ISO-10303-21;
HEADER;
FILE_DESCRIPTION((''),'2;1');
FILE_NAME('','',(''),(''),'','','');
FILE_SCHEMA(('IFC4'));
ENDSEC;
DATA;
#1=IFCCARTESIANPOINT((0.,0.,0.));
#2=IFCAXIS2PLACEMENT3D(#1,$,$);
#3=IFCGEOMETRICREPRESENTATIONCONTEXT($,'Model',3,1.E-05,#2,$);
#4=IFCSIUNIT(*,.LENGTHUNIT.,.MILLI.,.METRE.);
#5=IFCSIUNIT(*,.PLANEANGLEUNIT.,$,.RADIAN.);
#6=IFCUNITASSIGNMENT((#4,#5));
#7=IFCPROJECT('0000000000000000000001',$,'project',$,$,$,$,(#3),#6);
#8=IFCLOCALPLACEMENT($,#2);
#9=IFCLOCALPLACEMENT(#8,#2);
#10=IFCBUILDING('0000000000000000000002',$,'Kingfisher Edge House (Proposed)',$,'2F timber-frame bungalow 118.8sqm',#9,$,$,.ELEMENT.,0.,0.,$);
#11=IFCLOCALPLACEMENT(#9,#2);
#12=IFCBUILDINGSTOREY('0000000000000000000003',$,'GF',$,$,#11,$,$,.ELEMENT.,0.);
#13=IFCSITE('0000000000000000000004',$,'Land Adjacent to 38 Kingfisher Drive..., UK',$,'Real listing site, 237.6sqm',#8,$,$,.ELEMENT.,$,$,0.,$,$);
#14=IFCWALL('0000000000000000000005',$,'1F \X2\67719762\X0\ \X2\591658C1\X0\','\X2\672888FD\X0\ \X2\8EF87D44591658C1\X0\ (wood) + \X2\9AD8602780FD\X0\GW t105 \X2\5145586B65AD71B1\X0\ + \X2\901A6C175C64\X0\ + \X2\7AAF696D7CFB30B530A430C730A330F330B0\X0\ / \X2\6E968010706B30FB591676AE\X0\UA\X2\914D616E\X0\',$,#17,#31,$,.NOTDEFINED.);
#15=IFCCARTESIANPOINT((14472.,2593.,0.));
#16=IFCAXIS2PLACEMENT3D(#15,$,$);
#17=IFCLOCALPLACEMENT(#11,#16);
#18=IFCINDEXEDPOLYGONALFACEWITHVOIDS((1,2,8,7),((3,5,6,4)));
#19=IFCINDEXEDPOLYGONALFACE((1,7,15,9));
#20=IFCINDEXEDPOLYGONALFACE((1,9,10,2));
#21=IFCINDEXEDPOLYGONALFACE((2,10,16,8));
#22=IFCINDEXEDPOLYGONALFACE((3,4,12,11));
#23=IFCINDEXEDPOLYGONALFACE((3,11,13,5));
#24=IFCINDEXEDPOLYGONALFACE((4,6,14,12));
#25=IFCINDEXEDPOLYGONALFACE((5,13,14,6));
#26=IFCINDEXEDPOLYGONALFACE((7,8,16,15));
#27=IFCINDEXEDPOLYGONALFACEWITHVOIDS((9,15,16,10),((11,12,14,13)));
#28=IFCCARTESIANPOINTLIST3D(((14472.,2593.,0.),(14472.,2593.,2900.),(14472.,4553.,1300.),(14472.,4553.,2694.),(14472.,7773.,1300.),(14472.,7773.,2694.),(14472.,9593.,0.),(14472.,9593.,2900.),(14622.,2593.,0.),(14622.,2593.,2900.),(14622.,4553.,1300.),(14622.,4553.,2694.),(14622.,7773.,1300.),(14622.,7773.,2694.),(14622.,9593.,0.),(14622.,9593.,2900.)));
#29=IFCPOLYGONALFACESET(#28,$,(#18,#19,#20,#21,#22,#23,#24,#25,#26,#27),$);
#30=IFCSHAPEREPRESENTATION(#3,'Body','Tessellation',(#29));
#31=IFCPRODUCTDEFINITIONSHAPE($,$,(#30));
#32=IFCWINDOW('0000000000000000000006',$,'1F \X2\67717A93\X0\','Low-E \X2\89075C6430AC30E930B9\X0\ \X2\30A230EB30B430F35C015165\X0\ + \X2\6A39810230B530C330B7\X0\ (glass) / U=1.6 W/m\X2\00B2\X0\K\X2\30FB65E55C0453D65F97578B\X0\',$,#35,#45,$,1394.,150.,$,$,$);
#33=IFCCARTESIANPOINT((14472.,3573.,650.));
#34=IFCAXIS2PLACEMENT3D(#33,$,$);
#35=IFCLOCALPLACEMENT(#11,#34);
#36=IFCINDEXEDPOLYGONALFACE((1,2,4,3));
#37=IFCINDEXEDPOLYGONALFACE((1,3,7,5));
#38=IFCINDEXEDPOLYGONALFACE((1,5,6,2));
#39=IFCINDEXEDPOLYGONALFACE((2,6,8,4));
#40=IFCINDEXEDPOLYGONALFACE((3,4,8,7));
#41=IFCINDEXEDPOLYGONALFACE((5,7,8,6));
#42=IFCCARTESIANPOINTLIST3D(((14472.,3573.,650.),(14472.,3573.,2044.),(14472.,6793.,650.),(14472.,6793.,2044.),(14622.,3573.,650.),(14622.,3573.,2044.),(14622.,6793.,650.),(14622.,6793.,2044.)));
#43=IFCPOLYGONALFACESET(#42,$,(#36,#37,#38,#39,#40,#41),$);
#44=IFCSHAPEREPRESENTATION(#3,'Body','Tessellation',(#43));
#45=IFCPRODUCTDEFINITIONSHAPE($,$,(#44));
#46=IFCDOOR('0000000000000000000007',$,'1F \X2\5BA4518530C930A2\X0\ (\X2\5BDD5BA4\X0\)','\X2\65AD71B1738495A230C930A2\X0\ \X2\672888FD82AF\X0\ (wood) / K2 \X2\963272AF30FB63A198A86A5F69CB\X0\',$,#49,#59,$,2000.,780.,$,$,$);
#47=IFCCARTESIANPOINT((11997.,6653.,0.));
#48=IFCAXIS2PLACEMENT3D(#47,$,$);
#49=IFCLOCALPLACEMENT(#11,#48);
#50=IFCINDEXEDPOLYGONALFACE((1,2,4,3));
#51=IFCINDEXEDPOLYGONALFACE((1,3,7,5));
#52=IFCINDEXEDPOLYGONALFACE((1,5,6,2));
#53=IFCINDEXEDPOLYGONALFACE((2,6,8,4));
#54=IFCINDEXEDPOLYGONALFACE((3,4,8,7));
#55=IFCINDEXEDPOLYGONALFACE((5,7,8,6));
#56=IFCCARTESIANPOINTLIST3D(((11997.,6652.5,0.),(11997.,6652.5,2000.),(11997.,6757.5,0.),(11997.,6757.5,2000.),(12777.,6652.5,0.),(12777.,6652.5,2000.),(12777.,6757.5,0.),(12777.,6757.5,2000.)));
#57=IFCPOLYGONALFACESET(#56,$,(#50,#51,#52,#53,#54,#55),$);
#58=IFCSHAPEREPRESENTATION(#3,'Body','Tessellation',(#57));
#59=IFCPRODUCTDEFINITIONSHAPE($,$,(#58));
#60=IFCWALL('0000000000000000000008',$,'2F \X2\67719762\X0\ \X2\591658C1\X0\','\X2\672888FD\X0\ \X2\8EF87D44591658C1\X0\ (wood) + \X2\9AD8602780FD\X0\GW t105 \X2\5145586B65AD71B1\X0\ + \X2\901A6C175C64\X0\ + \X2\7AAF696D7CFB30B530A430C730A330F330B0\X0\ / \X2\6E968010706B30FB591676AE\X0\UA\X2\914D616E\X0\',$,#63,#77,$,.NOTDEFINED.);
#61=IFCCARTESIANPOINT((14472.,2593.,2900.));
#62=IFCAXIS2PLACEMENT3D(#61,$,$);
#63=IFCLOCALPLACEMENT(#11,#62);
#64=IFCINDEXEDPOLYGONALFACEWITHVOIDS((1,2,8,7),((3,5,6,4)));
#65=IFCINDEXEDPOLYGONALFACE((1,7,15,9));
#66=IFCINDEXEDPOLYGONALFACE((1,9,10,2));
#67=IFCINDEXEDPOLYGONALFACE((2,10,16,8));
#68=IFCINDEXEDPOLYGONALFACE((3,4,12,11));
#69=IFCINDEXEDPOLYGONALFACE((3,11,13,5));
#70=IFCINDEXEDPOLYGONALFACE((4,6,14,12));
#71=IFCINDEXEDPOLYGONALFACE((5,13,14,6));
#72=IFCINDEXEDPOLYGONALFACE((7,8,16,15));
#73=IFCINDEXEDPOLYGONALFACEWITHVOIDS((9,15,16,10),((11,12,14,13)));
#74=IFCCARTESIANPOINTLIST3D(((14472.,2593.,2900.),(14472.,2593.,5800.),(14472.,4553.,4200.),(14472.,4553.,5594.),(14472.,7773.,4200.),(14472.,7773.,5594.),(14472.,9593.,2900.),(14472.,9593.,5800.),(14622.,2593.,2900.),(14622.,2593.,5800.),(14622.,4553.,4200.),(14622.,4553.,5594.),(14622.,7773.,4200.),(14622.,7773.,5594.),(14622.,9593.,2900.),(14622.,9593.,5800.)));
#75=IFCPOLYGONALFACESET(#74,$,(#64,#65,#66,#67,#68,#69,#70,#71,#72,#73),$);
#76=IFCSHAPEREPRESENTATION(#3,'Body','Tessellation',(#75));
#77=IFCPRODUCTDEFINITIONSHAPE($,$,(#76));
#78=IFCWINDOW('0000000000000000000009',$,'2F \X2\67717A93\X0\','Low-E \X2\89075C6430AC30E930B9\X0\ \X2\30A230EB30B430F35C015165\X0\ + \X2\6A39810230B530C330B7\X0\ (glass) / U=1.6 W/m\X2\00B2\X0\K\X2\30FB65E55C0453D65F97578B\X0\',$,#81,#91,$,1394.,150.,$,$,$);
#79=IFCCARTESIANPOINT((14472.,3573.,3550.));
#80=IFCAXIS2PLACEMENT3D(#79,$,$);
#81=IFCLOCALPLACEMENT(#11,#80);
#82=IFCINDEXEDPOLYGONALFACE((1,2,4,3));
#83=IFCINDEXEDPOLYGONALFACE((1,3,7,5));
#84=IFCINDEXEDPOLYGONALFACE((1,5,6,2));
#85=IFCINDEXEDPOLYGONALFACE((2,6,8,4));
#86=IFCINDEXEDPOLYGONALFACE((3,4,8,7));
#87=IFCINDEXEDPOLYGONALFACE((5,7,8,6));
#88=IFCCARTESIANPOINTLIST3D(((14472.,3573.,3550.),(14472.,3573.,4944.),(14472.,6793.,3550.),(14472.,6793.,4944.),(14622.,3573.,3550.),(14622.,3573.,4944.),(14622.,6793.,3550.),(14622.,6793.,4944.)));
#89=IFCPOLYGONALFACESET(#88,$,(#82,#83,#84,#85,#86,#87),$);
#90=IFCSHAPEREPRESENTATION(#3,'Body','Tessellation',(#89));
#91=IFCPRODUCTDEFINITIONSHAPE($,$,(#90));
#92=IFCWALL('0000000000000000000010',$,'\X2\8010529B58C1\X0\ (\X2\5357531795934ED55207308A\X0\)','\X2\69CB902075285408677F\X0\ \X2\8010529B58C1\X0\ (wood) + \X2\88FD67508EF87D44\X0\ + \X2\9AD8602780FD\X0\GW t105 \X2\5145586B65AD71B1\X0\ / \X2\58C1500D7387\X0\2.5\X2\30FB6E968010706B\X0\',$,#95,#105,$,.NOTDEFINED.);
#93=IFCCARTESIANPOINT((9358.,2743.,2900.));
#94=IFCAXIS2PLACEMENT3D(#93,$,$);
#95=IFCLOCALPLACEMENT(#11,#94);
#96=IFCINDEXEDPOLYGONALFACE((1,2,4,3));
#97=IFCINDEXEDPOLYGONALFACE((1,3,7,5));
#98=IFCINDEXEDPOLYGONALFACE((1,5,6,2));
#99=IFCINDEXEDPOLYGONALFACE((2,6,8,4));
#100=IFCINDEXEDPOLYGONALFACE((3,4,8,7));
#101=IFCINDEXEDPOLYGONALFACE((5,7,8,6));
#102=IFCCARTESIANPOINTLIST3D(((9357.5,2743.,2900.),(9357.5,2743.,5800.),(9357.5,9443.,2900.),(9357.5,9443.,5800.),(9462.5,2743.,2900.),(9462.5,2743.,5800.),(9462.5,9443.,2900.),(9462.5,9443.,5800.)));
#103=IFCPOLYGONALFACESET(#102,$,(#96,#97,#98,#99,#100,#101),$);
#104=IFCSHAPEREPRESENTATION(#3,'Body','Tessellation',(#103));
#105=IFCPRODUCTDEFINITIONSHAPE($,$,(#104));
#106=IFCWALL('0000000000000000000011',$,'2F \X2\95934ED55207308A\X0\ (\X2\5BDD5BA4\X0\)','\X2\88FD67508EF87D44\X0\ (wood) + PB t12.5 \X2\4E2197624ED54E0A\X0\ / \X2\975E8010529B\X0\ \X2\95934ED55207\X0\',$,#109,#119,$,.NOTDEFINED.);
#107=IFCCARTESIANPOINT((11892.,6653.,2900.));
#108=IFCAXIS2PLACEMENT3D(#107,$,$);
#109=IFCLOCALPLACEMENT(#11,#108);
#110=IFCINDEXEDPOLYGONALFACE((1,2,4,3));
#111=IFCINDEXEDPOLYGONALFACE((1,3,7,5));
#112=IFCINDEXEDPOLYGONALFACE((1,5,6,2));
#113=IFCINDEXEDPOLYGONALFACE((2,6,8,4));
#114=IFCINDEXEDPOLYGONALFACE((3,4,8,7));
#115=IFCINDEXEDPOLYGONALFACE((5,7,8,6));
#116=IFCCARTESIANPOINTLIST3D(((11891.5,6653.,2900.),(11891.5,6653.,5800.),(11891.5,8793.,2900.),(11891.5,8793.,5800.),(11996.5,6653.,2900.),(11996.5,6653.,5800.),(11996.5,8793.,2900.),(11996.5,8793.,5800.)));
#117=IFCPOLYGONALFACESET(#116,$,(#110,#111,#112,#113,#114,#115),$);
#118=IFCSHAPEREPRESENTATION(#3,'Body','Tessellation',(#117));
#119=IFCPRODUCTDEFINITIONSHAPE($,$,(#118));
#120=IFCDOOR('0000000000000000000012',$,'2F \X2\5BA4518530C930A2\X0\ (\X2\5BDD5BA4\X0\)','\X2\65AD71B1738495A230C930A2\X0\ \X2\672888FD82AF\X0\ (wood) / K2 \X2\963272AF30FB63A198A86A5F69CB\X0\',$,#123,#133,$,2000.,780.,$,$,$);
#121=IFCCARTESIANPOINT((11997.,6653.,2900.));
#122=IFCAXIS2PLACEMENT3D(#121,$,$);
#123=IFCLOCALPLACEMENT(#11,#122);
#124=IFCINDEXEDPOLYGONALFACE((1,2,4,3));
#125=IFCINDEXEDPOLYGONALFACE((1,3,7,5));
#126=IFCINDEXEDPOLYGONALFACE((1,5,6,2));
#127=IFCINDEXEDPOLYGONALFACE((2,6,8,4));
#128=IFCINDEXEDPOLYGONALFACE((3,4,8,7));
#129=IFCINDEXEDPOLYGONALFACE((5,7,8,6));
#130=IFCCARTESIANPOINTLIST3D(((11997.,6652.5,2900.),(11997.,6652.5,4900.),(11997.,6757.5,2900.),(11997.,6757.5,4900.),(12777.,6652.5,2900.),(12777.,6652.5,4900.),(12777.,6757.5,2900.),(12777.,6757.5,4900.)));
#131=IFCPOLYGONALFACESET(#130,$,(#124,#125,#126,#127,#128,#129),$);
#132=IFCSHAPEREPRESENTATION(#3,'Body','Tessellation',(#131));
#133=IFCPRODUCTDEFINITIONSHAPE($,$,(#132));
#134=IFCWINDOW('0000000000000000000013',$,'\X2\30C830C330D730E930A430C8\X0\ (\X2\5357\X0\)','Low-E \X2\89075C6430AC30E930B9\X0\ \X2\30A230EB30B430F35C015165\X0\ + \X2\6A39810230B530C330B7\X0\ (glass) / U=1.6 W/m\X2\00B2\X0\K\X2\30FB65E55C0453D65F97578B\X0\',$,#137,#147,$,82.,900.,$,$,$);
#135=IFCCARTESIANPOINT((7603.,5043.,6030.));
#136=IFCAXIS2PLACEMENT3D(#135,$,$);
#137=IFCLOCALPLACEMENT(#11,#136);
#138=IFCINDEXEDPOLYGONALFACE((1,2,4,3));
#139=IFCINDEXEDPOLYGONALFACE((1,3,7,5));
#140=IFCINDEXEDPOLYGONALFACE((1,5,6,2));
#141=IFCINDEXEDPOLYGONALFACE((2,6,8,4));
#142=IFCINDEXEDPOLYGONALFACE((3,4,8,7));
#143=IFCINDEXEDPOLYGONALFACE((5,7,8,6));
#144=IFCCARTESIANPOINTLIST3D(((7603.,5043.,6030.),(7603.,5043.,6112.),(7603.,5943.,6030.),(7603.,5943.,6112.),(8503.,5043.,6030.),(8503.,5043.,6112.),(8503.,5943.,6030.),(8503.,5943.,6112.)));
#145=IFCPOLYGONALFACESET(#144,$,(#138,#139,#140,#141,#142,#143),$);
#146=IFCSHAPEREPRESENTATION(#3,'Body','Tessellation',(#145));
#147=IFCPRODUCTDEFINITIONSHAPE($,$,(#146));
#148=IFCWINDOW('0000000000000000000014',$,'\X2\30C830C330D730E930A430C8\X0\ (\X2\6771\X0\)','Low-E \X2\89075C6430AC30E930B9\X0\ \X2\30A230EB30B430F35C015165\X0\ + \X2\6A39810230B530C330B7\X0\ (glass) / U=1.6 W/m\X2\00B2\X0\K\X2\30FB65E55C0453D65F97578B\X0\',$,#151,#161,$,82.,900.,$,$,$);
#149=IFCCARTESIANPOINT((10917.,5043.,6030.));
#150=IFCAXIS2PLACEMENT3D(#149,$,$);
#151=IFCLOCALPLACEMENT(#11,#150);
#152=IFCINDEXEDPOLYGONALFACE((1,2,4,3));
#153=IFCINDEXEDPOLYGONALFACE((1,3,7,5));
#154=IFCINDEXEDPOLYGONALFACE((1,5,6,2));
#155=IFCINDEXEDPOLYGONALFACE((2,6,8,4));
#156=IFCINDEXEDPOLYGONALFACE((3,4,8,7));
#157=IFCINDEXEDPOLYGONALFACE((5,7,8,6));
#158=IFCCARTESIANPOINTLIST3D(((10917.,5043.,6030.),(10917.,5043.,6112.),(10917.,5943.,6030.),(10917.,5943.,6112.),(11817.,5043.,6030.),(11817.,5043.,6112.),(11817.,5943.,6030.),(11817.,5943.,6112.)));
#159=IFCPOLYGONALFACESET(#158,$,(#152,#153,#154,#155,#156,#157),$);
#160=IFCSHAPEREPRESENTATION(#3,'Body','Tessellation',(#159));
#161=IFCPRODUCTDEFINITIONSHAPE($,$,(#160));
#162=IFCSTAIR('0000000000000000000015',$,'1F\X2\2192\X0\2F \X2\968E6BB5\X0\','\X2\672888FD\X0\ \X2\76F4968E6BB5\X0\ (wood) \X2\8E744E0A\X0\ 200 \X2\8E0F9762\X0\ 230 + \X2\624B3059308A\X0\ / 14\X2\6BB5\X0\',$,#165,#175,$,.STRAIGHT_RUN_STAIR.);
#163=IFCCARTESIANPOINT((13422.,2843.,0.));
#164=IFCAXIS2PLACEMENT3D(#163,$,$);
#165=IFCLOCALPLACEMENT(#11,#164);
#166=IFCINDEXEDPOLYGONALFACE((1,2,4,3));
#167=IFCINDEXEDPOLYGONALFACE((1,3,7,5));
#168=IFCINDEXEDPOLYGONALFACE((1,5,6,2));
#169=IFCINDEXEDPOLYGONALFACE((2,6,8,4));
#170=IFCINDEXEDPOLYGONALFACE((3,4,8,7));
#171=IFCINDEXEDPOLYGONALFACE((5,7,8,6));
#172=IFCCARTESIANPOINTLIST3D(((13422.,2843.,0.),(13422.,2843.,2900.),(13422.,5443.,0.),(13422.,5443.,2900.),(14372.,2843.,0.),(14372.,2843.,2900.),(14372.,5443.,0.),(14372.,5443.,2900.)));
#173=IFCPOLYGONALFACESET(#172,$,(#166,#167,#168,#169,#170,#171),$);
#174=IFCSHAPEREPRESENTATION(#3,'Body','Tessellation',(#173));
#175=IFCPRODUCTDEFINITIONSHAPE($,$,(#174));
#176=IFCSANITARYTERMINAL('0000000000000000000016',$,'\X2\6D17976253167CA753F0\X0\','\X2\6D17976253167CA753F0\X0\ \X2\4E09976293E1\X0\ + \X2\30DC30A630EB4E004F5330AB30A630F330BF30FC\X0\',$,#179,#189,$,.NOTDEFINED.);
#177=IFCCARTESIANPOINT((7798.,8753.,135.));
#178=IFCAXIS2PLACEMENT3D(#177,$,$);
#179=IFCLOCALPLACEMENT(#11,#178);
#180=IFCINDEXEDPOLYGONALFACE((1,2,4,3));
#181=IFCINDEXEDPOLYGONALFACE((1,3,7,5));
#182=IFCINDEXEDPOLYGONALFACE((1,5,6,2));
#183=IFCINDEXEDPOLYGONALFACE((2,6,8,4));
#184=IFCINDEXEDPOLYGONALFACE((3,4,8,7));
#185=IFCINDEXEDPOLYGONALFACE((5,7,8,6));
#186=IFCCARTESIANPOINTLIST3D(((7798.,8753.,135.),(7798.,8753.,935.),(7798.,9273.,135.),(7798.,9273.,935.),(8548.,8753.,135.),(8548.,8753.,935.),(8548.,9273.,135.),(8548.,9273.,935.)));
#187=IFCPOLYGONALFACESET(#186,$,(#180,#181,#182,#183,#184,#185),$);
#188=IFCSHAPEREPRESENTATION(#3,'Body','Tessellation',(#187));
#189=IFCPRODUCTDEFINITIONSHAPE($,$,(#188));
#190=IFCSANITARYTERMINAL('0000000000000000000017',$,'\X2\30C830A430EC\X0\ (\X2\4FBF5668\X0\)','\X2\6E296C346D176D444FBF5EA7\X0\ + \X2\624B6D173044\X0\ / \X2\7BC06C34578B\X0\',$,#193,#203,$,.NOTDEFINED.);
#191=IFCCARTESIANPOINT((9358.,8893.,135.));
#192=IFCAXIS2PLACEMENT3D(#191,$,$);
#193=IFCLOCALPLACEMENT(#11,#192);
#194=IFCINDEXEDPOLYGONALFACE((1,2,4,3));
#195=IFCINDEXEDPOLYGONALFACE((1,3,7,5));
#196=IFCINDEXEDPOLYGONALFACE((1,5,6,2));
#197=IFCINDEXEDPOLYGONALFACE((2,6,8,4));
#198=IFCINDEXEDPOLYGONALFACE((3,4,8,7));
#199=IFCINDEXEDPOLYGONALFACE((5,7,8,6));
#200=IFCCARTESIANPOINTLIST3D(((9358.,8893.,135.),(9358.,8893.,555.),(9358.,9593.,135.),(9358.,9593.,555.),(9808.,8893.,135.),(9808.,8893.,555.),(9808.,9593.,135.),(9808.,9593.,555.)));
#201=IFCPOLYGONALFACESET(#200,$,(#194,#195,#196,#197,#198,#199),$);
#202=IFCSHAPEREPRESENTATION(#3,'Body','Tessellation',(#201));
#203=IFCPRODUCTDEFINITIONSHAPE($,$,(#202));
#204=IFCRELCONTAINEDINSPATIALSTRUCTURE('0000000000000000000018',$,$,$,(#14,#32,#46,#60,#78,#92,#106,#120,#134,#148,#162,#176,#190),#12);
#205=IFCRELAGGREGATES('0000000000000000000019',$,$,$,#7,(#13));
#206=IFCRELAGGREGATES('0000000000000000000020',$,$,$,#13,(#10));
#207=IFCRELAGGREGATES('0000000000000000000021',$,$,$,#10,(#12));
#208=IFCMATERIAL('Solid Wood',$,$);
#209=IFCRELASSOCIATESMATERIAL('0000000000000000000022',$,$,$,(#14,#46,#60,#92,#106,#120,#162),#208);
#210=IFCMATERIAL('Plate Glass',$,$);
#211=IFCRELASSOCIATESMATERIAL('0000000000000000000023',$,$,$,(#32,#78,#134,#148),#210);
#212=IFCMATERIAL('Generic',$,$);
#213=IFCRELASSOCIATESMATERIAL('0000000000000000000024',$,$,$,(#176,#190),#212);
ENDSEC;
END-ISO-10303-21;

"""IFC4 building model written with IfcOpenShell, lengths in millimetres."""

from ifc_helpers import new_model, si_unit, frame, frame_2d, origin, place, context, project, spatial, rectangle, extrude, material, element, fill, save


model = new_model("IFC4")

# Units and contexts
model_context = context("Model", 3, precision=1e-05, world=origin())
ifc_project = project(units=[si_unit("LENGTHUNIT", "METRE", prefix="MILLI"), si_unit("PLANEANGLEUNIT", "RADIAN")], contexts=[model_context])

# Site, building, storey
site_placement = place(None, origin())
site = spatial("IfcSite", under=ifc_project, at=site_placement, Name="Land Adjacent to 38 Kingfisher Drive..., UK", ObjectType="Real listing site, 237.6sqm", CompositionType="ELEMENT", RefElevation=0.0)
building_placement = place(site_placement, origin())
building = spatial("IfcBuilding", under=site, at=building_placement, Name="Kingfisher Edge House (Proposed)", ObjectType="2F timber-frame bungalow 118.8sqm", CompositionType="ELEMENT", ElevationOfRefHeight=0.0, ElevationOfTerrain=0.0)
storey_placement = place(building_placement, origin())
storey = spatial("IfcBuildingStorey", under=building, at=storey_placement, Name="GF", CompositionType="ELEMENT", Elevation=0.0)

# Wall, opening, window
ifc_material_1 = material(Name="Solid Wood")
wall_1_placement = place(storey_placement, frame((14472.0, 2593.0, 0.0)))
wall_1 = element("IfcWall", 1, at=wall_1_placement, inside=storey, material=ifc_material_1, Name="1F 東面 外壁", Description="木製 軸組外壁 (wood) + 高性能GW t105 充填断熱 + 通気層 + 窯業系サイディング / 準耐火・外皮UA配慮", PredefinedType="NOTDEFINED", context=model_context, shape_type="SweptSolid", body=[
    extrude(rectangle(XDim=150.0, YDim=7000.0, at=frame_2d((75.0, 3500.0))), frame((14472.0, 2593.0, 0.0)), (0.0, 0.0, 1.0), 2900.0),
])
opening_1_placement = place(storey_placement, frame((14472.0, 3573.0, 650.0)))
opening_1 = element("IfcOpeningElement", 2, at=opening_1_placement, cuts=wall_1, PredefinedType="NOTDEFINED", context=model_context, shape_type="SweptSolid", body=[
    extrude(rectangle(XDim=150.0, YDim=3220.0, at=frame_2d((75.0, 1610.0))), frame((14472.0, 3573.0, 650.0)), (0.0, 0.0, 1.0), 1394.0),
])
ifc_material_2 = material(Name="Plate Glass")
window_1_placement = place(storey_placement, frame((14472.0, 3573.0, 650.0)))
window_1 = element("IfcWindow", 3, at=window_1_placement, inside=storey, material=ifc_material_2, Name="1F 東窓", Description="Low-E 複層ガラス アルゴン封入 + 樹脂サッシ (glass) / U=1.6 W/m²K・日射取得型", OverallHeight=1394.0, OverallWidth=150.0, context=model_context, shape_type="SweptSolid", body=[
    extrude(rectangle(XDim=150.0, YDim=3220.0, at=frame_2d((75.0, 1610.0))), frame((14472.0, 3573.0, 650.0)), (0.0, 0.0, 1.0), 1394.0),
])
fill(opening_1, window_1)

# Door
door_1_placement = place(storey_placement, frame((11997.0, 6653.0, 0.0)))
element("IfcDoor", 4, at=door_1_placement, inside=storey, material=ifc_material_1, Name="1F 室内ドア (寝室)", Description="断熱玄関ドア 木製芯 (wood) / K2 防犯・採風機構", OverallHeight=2000.0, OverallWidth=780.0, context=model_context, shape_type="SweptSolid", body=[
    extrude(rectangle(XDim=780.0, YDim=105.0, at=frame_2d((390.0, 52.0))), frame((11997.0, 6653.0, 0.0)), (0.0, 0.0, 1.0), 2000.0),
])

# Wall, opening, window
wall_2_placement = place(storey_placement, frame((14472.0, 2593.0, 2900.0)))
wall_2 = element("IfcWall", 5, at=wall_2_placement, inside=storey, material=ifc_material_1, Name="2F 東面 外壁", Description="木製 軸組外壁 (wood) + 高性能GW t105 充填断熱 + 通気層 + 窯業系サイディング / 準耐火・外皮UA配慮", PredefinedType="NOTDEFINED", context=model_context, shape_type="SweptSolid", body=[
    extrude(rectangle(XDim=150.0, YDim=7000.0, at=frame_2d((75.0, 3500.0))), frame((14472.0, 2593.0, 2900.0)), (0.0, 0.0, 1.0), 2900.0),
])
opening_2_placement = place(storey_placement, frame((14472.0, 3573.0, 3550.0)))
opening_2 = element("IfcOpeningElement", 6, at=opening_2_placement, cuts=wall_2, PredefinedType="NOTDEFINED", context=model_context, shape_type="SweptSolid", body=[
    extrude(rectangle(XDim=150.0, YDim=3220.0, at=frame_2d((75.0, 1610.0))), frame((14472.0, 3573.0, 3550.0)), (0.0, 0.0, 1.0), 1394.0),
])
window_2_placement = place(storey_placement, frame((14472.0, 3573.0, 3550.0)))
window_2 = element("IfcWindow", 7, at=window_2_placement, inside=storey, material=ifc_material_2, Name="2F 東窓", Description="Low-E 複層ガラス アルゴン封入 + 樹脂サッシ (glass) / U=1.6 W/m²K・日射取得型", OverallHeight=1394.0, OverallWidth=150.0, context=model_context, shape_type="SweptSolid", body=[
    extrude(rectangle(XDim=150.0, YDim=3220.0, at=frame_2d((75.0, 1610.0))), frame((14472.0, 3573.0, 3550.0)), (0.0, 0.0, 1.0), 1394.0),
])
fill(opening_2, window_2)

# Walls
wall_3_placement = place(storey_placement, frame((9358.0, 2743.0, 2900.0)))
element("IfcWall", 8, at=wall_3_placement, inside=storey, material=ifc_material_1, Name="耐力壁 (南北間仕切り)", Description="構造用合板 耐力壁 (wood) + 製材軸組 + 高性能GW t105 充填断熱 / 壁倍率2.5・準耐火", PredefinedType="NOTDEFINED", context=model_context, shape_type="SweptSolid", body=[
    extrude(rectangle(XDim=105.0, YDim=6700.0, at=frame_2d((52.0, 3350.0))), frame((9358.0, 2743.0, 2900.0)), (0.0, 0.0, 1.0), 2900.0),
])
wall_4_placement = place(storey_placement, frame((11892.0, 6653.0, 2900.0)))
element("IfcWall", 9, at=wall_4_placement, inside=storey, material=ifc_material_1, Name="2F 間仕切り (寝室)", Description="製材軸組 (wood) + PB t12.5 両面仕上 / 非耐力 間仕切", PredefinedType="NOTDEFINED", context=model_context, shape_type="SweptSolid", body=[
    extrude(rectangle(XDim=105.0, YDim=2140.0, at=frame_2d((52.0, 1070.0))), frame((11892.0, 6653.0, 2900.0)), (0.0, 0.0, 1.0), 2900.0),
])

# Door
door_2_placement = place(storey_placement, frame((11997.0, 6653.0, 2900.0)))
element("IfcDoor", 10, at=door_2_placement, inside=storey, material=ifc_material_1, Name="2F 室内ドア (寝室)", Description="断熱玄関ドア 木製芯 (wood) / K2 防犯・採風機構", OverallHeight=2000.0, OverallWidth=780.0, context=model_context, shape_type="SweptSolid", body=[
    extrude(rectangle(XDim=780.0, YDim=105.0, at=frame_2d((390.0, 52.0))), frame((11997.0, 6653.0, 2900.0)), (0.0, 0.0, 1.0), 2000.0),
])

# Windows
window_3_placement = place(storey_placement, frame((7603.0, 5043.0, 6030.0)))
element("IfcWindow", 11, at=window_3_placement, inside=storey, material=ifc_material_2, Name="トップライト (南)", Description="Low-E 複層ガラス アルゴン封入 + 樹脂サッシ (glass) / U=1.6 W/m²K・日射取得型", OverallHeight=82.0, OverallWidth=900.0, context=model_context, shape_type="SweptSolid", body=[
    extrude(rectangle(XDim=900.0, YDim=900.0, at=frame_2d((450.0, 450.0))), frame((7603.0, 5043.0, 6030.0)), (0.0, 0.0, 1.0), 82.0),
])
window_4_placement = place(storey_placement, frame((10917.0, 5043.0, 6030.0)))
element("IfcWindow", 12, at=window_4_placement, inside=storey, material=ifc_material_2, Name="トップライト (東)", Description="Low-E 複層ガラス アルゴン封入 + 樹脂サッシ (glass) / U=1.6 W/m²K・日射取得型", OverallHeight=82.0, OverallWidth=900.0, context=model_context, shape_type="SweptSolid", body=[
    extrude(rectangle(XDim=900.0, YDim=900.0, at=frame_2d((450.0, 450.0))), frame((10917.0, 5043.0, 6030.0)), (0.0, 0.0, 1.0), 82.0),
])

# Stair
stair_placement = place(storey_placement, frame((13422.0, 2843.0, 0.0)))
element("IfcStair", 13, at=stair_placement, inside=storey, material=ifc_material_1, Name="1F→2F 階段", Description="木製 直階段 (wood) 蹴上 200 踏面 230 + 手すり / 14段", PredefinedType="STRAIGHT_RUN_STAIR", context=model_context, shape_type="SweptSolid", body=[
    extrude(rectangle(XDim=950.0, YDim=2600.0, at=frame_2d((475.0, 1300.0))), frame((13422.0, 2843.0, 0.0)), (0.0, 0.0, 1.0), 2900.0),
])

# Sanitary terminals
ifc_material_3 = material(Name="Generic")
sanitary_terminal_1_placement = place(storey_placement, frame((7798.0, 8753.0, 135.0)))
element("IfcSanitaryTerminal", 14, at=sanitary_terminal_1_placement, inside=storey, material=ifc_material_3, Name="洗面化粧台", Description="洗面化粧台 三面鏡 + ボウル一体カウンター", PredefinedType="NOTDEFINED", context=model_context, shape_type="SweptSolid", body=[
    extrude(rectangle(XDim=750.0, YDim=520.0, at=frame_2d((375.0, 260.0))), frame((7798.0, 8753.0, 135.0)), (0.0, 0.0, 1.0), 800.0),
])
sanitary_terminal_2_placement = place(storey_placement, frame((9358.0, 8893.0, 135.0)))
element("IfcSanitaryTerminal", 15, at=sanitary_terminal_2_placement, inside=storey, material=ifc_material_3, Name="トイレ (便器)", Description="温水洗浄便座 + 手洗い / 節水型", PredefinedType="NOTDEFINED", context=model_context, shape_type="SweptSolid", body=[
    extrude(rectangle(XDim=450.0, YDim=700.0, at=frame_2d((225.0, 350.0))), frame((9358.0, 8893.0, 135.0)), (0.0, 0.0, 1.0), 420.0),
])

save(model, "model.ifc")
